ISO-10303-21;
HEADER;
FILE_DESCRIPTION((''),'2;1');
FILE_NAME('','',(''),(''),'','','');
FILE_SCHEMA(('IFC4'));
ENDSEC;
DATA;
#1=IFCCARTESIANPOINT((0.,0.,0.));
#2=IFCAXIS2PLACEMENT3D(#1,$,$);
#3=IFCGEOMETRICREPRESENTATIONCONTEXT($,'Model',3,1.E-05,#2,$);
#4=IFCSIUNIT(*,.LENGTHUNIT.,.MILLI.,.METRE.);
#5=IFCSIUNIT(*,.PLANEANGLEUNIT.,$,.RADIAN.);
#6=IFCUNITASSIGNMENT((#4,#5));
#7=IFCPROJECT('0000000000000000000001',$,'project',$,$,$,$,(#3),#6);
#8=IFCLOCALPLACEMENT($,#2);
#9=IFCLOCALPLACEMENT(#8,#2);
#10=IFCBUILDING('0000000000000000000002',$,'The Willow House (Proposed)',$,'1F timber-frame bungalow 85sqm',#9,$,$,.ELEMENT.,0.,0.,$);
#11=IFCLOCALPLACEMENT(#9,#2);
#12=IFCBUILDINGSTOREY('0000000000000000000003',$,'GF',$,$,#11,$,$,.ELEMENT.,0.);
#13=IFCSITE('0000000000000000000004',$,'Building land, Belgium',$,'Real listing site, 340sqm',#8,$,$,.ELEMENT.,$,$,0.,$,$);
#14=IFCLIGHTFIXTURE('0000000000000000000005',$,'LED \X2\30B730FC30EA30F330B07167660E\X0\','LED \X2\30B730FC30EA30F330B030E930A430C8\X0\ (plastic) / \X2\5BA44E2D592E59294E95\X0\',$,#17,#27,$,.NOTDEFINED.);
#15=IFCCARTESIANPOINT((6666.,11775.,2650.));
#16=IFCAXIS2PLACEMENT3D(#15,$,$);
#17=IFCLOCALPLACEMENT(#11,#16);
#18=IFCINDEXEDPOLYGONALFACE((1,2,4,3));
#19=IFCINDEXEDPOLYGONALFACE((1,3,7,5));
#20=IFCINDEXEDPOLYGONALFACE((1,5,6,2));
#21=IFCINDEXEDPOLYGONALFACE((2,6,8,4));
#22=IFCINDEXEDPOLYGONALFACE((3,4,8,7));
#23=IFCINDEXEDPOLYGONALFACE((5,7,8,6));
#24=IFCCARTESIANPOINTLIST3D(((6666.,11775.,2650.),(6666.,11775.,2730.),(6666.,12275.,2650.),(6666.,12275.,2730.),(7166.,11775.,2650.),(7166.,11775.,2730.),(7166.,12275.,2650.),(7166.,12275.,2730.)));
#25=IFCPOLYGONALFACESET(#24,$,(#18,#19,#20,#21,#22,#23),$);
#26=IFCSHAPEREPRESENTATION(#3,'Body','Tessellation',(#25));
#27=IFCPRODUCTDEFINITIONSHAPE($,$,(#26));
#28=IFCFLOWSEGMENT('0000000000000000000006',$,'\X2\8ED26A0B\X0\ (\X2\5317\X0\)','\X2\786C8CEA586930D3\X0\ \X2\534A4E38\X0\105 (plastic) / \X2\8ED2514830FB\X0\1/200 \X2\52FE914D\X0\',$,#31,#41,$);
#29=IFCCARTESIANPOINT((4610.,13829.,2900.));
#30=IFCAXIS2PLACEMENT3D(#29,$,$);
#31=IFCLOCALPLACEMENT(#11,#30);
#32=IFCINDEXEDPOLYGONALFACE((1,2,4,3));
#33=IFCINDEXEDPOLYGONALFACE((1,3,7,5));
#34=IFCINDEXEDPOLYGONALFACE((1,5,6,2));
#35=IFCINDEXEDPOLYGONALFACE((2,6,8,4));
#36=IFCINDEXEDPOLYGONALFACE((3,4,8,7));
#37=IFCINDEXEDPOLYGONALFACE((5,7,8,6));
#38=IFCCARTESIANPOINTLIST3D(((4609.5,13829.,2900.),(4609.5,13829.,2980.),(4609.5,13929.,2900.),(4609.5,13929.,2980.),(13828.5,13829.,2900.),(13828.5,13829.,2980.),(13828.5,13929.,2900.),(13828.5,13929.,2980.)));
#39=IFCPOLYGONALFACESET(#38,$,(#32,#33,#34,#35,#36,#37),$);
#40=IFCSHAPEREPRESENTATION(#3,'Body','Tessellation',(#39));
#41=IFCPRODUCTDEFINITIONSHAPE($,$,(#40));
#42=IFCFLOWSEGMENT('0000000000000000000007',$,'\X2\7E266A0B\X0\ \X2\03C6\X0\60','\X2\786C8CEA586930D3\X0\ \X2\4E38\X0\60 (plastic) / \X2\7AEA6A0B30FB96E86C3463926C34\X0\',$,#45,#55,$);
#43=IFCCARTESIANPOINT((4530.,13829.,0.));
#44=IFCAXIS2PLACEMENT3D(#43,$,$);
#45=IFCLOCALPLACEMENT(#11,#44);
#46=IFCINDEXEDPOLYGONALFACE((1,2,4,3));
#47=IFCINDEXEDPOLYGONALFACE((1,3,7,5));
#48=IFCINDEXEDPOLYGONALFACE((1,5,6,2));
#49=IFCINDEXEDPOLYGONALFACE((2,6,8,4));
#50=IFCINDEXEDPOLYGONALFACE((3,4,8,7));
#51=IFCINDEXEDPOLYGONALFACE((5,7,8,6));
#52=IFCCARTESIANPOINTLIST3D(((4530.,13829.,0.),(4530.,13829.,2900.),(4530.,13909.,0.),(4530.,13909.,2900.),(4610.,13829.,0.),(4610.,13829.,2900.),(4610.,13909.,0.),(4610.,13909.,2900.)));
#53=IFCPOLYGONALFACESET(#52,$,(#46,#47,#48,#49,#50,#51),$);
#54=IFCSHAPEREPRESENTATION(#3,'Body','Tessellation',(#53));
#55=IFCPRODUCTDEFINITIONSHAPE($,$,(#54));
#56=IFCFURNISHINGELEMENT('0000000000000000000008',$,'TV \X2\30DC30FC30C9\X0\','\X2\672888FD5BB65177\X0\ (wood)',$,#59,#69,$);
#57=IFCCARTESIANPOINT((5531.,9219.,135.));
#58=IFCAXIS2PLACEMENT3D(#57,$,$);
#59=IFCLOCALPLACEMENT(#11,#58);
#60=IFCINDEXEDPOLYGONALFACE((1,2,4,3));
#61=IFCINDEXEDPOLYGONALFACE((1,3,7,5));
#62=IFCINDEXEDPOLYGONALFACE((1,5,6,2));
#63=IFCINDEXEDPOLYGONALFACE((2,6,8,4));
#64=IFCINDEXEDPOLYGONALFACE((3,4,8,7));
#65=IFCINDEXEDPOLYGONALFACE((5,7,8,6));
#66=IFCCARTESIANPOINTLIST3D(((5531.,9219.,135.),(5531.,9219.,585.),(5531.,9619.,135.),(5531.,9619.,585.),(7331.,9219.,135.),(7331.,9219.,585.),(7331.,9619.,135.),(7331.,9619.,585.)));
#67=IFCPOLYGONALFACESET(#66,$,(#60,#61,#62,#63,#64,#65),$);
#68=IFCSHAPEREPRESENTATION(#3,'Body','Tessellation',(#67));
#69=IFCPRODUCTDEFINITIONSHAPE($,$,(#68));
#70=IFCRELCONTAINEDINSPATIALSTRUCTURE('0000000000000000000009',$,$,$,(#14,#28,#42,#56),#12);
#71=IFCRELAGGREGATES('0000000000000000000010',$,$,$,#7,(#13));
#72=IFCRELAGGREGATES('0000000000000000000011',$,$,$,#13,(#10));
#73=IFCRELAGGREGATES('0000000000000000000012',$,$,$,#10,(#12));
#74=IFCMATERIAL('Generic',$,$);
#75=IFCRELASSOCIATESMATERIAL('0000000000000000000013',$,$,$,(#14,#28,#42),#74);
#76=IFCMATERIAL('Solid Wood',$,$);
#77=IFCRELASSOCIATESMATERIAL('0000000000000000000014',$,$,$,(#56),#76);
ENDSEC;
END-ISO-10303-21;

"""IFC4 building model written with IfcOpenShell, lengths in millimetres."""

from ifc_helpers import new_model, si_unit, frame, frame_2d, origin, place, context, project, spatial, rectangle, extrude, material, element, save


model = new_model("IFC4")

# Units and contexts
model_context = context("Model", 3, precision=1e-05, world=origin())
ifc_project = project(units=[si_unit("LENGTHUNIT", "METRE", prefix="MILLI"), si_unit("PLANEANGLEUNIT", "RADIAN")], contexts=[model_context])

# Site, building, storey
site_placement = place(None, origin())
site = spatial("IfcSite", under=ifc_project, at=site_placement, Name="Building land, Belgium", ObjectType="Real listing site, 340sqm", CompositionType="ELEMENT", RefElevation=0.0)
building_placement = place(site_placement, origin())
building = spatial("IfcBuilding", under=site, at=building_placement, Name="The Willow House (Proposed)", ObjectType="1F timber-frame bungalow 85sqm", CompositionType="ELEMENT", ElevationOfRefHeight=0.0, ElevationOfTerrain=0.0)
storey_placement = place(building_placement, origin())
storey = spatial("IfcBuildingStorey", under=building, at=storey_placement, Name="GF", CompositionType="ELEMENT", Elevation=0.0)

# Shared definitions
ifc_material_1 = material(Name="Solid Wood")

# Shared definitions
ifc_material_2 = material(Name="Generic")

# Light fixture
light_fixture_placement = place(storey_placement, frame((6666.0, 11775.0, 2650.0)))
element("IfcLightFixture", 1, at=light_fixture_placement, inside=storey, material=ifc_material_2, Name="LED シーリング照明", Description="LED シーリングライト (plastic) / 室中央天井", PredefinedType="NOTDEFINED", context=model_context, shape_type="SweptSolid", body=[
    extrude(rectangle(XDim=500.0, YDim=500.0, at=frame_2d((250.0, 250.0))), frame((6666.0, 11775.0, 2650.0)), (0.0, 0.0, 1.0), 80.0),
])

# Flow segments
flow_segment_1_placement = place(storey_placement, frame((4610.0, 13829.0, 2900.0)))
element("IfcFlowSegment", 2, at=flow_segment_1_placement, inside=storey, material=ifc_material_2, Name="軒樋 (北)", Description="硬質塩ビ 半丸105 (plastic) / 軒先・1/200 勾配", context=model_context, shape_type="SweptSolid", body=[
    extrude(rectangle(XDim=9219.0, YDim=100.0, at=frame_2d((4609.0, 50.0))), frame((4610.0, 13829.0, 2900.0)), (0.0, 0.0, 1.0), 80.0),
])
flow_segment_2_placement = place(storey_placement, frame((4530.0, 13829.0, 0.0)))
element("IfcFlowSegment", 3, at=flow_segment_2_placement, inside=storey, material=ifc_material_2, Name="縦樋 φ60", Description="硬質塩ビ 丸60 (plastic) / 竪樋・雨水排水", context=model_context, shape_type="SweptSolid", body=[
    extrude(rectangle(XDim=80.0, YDim=80.0, at=frame_2d((40.0, 40.0))), frame((4530.0, 13829.0, 0.0)), (0.0, 0.0, 1.0), 2900.0),
])

# Furnishing element
furnishing_placement = place(storey_placement, frame((5531.0, 9219.0, 135.0)))
element("IfcFurnishingElement", 4, at=furnishing_placement, inside=storey, material=ifc_material_1, Name="TV ボード", Description="木製家具 (wood)", context=model_context, shape_type="SweptSolid", body=[
    extrude(rectangle(XDim=1800.0, YDim=400.0, at=frame_2d((900.0, 200.0))), frame((5531.0, 9219.0, 135.0)), (0.0, 0.0, 1.0), 450.0),
])

save(model, "model.ifc")
